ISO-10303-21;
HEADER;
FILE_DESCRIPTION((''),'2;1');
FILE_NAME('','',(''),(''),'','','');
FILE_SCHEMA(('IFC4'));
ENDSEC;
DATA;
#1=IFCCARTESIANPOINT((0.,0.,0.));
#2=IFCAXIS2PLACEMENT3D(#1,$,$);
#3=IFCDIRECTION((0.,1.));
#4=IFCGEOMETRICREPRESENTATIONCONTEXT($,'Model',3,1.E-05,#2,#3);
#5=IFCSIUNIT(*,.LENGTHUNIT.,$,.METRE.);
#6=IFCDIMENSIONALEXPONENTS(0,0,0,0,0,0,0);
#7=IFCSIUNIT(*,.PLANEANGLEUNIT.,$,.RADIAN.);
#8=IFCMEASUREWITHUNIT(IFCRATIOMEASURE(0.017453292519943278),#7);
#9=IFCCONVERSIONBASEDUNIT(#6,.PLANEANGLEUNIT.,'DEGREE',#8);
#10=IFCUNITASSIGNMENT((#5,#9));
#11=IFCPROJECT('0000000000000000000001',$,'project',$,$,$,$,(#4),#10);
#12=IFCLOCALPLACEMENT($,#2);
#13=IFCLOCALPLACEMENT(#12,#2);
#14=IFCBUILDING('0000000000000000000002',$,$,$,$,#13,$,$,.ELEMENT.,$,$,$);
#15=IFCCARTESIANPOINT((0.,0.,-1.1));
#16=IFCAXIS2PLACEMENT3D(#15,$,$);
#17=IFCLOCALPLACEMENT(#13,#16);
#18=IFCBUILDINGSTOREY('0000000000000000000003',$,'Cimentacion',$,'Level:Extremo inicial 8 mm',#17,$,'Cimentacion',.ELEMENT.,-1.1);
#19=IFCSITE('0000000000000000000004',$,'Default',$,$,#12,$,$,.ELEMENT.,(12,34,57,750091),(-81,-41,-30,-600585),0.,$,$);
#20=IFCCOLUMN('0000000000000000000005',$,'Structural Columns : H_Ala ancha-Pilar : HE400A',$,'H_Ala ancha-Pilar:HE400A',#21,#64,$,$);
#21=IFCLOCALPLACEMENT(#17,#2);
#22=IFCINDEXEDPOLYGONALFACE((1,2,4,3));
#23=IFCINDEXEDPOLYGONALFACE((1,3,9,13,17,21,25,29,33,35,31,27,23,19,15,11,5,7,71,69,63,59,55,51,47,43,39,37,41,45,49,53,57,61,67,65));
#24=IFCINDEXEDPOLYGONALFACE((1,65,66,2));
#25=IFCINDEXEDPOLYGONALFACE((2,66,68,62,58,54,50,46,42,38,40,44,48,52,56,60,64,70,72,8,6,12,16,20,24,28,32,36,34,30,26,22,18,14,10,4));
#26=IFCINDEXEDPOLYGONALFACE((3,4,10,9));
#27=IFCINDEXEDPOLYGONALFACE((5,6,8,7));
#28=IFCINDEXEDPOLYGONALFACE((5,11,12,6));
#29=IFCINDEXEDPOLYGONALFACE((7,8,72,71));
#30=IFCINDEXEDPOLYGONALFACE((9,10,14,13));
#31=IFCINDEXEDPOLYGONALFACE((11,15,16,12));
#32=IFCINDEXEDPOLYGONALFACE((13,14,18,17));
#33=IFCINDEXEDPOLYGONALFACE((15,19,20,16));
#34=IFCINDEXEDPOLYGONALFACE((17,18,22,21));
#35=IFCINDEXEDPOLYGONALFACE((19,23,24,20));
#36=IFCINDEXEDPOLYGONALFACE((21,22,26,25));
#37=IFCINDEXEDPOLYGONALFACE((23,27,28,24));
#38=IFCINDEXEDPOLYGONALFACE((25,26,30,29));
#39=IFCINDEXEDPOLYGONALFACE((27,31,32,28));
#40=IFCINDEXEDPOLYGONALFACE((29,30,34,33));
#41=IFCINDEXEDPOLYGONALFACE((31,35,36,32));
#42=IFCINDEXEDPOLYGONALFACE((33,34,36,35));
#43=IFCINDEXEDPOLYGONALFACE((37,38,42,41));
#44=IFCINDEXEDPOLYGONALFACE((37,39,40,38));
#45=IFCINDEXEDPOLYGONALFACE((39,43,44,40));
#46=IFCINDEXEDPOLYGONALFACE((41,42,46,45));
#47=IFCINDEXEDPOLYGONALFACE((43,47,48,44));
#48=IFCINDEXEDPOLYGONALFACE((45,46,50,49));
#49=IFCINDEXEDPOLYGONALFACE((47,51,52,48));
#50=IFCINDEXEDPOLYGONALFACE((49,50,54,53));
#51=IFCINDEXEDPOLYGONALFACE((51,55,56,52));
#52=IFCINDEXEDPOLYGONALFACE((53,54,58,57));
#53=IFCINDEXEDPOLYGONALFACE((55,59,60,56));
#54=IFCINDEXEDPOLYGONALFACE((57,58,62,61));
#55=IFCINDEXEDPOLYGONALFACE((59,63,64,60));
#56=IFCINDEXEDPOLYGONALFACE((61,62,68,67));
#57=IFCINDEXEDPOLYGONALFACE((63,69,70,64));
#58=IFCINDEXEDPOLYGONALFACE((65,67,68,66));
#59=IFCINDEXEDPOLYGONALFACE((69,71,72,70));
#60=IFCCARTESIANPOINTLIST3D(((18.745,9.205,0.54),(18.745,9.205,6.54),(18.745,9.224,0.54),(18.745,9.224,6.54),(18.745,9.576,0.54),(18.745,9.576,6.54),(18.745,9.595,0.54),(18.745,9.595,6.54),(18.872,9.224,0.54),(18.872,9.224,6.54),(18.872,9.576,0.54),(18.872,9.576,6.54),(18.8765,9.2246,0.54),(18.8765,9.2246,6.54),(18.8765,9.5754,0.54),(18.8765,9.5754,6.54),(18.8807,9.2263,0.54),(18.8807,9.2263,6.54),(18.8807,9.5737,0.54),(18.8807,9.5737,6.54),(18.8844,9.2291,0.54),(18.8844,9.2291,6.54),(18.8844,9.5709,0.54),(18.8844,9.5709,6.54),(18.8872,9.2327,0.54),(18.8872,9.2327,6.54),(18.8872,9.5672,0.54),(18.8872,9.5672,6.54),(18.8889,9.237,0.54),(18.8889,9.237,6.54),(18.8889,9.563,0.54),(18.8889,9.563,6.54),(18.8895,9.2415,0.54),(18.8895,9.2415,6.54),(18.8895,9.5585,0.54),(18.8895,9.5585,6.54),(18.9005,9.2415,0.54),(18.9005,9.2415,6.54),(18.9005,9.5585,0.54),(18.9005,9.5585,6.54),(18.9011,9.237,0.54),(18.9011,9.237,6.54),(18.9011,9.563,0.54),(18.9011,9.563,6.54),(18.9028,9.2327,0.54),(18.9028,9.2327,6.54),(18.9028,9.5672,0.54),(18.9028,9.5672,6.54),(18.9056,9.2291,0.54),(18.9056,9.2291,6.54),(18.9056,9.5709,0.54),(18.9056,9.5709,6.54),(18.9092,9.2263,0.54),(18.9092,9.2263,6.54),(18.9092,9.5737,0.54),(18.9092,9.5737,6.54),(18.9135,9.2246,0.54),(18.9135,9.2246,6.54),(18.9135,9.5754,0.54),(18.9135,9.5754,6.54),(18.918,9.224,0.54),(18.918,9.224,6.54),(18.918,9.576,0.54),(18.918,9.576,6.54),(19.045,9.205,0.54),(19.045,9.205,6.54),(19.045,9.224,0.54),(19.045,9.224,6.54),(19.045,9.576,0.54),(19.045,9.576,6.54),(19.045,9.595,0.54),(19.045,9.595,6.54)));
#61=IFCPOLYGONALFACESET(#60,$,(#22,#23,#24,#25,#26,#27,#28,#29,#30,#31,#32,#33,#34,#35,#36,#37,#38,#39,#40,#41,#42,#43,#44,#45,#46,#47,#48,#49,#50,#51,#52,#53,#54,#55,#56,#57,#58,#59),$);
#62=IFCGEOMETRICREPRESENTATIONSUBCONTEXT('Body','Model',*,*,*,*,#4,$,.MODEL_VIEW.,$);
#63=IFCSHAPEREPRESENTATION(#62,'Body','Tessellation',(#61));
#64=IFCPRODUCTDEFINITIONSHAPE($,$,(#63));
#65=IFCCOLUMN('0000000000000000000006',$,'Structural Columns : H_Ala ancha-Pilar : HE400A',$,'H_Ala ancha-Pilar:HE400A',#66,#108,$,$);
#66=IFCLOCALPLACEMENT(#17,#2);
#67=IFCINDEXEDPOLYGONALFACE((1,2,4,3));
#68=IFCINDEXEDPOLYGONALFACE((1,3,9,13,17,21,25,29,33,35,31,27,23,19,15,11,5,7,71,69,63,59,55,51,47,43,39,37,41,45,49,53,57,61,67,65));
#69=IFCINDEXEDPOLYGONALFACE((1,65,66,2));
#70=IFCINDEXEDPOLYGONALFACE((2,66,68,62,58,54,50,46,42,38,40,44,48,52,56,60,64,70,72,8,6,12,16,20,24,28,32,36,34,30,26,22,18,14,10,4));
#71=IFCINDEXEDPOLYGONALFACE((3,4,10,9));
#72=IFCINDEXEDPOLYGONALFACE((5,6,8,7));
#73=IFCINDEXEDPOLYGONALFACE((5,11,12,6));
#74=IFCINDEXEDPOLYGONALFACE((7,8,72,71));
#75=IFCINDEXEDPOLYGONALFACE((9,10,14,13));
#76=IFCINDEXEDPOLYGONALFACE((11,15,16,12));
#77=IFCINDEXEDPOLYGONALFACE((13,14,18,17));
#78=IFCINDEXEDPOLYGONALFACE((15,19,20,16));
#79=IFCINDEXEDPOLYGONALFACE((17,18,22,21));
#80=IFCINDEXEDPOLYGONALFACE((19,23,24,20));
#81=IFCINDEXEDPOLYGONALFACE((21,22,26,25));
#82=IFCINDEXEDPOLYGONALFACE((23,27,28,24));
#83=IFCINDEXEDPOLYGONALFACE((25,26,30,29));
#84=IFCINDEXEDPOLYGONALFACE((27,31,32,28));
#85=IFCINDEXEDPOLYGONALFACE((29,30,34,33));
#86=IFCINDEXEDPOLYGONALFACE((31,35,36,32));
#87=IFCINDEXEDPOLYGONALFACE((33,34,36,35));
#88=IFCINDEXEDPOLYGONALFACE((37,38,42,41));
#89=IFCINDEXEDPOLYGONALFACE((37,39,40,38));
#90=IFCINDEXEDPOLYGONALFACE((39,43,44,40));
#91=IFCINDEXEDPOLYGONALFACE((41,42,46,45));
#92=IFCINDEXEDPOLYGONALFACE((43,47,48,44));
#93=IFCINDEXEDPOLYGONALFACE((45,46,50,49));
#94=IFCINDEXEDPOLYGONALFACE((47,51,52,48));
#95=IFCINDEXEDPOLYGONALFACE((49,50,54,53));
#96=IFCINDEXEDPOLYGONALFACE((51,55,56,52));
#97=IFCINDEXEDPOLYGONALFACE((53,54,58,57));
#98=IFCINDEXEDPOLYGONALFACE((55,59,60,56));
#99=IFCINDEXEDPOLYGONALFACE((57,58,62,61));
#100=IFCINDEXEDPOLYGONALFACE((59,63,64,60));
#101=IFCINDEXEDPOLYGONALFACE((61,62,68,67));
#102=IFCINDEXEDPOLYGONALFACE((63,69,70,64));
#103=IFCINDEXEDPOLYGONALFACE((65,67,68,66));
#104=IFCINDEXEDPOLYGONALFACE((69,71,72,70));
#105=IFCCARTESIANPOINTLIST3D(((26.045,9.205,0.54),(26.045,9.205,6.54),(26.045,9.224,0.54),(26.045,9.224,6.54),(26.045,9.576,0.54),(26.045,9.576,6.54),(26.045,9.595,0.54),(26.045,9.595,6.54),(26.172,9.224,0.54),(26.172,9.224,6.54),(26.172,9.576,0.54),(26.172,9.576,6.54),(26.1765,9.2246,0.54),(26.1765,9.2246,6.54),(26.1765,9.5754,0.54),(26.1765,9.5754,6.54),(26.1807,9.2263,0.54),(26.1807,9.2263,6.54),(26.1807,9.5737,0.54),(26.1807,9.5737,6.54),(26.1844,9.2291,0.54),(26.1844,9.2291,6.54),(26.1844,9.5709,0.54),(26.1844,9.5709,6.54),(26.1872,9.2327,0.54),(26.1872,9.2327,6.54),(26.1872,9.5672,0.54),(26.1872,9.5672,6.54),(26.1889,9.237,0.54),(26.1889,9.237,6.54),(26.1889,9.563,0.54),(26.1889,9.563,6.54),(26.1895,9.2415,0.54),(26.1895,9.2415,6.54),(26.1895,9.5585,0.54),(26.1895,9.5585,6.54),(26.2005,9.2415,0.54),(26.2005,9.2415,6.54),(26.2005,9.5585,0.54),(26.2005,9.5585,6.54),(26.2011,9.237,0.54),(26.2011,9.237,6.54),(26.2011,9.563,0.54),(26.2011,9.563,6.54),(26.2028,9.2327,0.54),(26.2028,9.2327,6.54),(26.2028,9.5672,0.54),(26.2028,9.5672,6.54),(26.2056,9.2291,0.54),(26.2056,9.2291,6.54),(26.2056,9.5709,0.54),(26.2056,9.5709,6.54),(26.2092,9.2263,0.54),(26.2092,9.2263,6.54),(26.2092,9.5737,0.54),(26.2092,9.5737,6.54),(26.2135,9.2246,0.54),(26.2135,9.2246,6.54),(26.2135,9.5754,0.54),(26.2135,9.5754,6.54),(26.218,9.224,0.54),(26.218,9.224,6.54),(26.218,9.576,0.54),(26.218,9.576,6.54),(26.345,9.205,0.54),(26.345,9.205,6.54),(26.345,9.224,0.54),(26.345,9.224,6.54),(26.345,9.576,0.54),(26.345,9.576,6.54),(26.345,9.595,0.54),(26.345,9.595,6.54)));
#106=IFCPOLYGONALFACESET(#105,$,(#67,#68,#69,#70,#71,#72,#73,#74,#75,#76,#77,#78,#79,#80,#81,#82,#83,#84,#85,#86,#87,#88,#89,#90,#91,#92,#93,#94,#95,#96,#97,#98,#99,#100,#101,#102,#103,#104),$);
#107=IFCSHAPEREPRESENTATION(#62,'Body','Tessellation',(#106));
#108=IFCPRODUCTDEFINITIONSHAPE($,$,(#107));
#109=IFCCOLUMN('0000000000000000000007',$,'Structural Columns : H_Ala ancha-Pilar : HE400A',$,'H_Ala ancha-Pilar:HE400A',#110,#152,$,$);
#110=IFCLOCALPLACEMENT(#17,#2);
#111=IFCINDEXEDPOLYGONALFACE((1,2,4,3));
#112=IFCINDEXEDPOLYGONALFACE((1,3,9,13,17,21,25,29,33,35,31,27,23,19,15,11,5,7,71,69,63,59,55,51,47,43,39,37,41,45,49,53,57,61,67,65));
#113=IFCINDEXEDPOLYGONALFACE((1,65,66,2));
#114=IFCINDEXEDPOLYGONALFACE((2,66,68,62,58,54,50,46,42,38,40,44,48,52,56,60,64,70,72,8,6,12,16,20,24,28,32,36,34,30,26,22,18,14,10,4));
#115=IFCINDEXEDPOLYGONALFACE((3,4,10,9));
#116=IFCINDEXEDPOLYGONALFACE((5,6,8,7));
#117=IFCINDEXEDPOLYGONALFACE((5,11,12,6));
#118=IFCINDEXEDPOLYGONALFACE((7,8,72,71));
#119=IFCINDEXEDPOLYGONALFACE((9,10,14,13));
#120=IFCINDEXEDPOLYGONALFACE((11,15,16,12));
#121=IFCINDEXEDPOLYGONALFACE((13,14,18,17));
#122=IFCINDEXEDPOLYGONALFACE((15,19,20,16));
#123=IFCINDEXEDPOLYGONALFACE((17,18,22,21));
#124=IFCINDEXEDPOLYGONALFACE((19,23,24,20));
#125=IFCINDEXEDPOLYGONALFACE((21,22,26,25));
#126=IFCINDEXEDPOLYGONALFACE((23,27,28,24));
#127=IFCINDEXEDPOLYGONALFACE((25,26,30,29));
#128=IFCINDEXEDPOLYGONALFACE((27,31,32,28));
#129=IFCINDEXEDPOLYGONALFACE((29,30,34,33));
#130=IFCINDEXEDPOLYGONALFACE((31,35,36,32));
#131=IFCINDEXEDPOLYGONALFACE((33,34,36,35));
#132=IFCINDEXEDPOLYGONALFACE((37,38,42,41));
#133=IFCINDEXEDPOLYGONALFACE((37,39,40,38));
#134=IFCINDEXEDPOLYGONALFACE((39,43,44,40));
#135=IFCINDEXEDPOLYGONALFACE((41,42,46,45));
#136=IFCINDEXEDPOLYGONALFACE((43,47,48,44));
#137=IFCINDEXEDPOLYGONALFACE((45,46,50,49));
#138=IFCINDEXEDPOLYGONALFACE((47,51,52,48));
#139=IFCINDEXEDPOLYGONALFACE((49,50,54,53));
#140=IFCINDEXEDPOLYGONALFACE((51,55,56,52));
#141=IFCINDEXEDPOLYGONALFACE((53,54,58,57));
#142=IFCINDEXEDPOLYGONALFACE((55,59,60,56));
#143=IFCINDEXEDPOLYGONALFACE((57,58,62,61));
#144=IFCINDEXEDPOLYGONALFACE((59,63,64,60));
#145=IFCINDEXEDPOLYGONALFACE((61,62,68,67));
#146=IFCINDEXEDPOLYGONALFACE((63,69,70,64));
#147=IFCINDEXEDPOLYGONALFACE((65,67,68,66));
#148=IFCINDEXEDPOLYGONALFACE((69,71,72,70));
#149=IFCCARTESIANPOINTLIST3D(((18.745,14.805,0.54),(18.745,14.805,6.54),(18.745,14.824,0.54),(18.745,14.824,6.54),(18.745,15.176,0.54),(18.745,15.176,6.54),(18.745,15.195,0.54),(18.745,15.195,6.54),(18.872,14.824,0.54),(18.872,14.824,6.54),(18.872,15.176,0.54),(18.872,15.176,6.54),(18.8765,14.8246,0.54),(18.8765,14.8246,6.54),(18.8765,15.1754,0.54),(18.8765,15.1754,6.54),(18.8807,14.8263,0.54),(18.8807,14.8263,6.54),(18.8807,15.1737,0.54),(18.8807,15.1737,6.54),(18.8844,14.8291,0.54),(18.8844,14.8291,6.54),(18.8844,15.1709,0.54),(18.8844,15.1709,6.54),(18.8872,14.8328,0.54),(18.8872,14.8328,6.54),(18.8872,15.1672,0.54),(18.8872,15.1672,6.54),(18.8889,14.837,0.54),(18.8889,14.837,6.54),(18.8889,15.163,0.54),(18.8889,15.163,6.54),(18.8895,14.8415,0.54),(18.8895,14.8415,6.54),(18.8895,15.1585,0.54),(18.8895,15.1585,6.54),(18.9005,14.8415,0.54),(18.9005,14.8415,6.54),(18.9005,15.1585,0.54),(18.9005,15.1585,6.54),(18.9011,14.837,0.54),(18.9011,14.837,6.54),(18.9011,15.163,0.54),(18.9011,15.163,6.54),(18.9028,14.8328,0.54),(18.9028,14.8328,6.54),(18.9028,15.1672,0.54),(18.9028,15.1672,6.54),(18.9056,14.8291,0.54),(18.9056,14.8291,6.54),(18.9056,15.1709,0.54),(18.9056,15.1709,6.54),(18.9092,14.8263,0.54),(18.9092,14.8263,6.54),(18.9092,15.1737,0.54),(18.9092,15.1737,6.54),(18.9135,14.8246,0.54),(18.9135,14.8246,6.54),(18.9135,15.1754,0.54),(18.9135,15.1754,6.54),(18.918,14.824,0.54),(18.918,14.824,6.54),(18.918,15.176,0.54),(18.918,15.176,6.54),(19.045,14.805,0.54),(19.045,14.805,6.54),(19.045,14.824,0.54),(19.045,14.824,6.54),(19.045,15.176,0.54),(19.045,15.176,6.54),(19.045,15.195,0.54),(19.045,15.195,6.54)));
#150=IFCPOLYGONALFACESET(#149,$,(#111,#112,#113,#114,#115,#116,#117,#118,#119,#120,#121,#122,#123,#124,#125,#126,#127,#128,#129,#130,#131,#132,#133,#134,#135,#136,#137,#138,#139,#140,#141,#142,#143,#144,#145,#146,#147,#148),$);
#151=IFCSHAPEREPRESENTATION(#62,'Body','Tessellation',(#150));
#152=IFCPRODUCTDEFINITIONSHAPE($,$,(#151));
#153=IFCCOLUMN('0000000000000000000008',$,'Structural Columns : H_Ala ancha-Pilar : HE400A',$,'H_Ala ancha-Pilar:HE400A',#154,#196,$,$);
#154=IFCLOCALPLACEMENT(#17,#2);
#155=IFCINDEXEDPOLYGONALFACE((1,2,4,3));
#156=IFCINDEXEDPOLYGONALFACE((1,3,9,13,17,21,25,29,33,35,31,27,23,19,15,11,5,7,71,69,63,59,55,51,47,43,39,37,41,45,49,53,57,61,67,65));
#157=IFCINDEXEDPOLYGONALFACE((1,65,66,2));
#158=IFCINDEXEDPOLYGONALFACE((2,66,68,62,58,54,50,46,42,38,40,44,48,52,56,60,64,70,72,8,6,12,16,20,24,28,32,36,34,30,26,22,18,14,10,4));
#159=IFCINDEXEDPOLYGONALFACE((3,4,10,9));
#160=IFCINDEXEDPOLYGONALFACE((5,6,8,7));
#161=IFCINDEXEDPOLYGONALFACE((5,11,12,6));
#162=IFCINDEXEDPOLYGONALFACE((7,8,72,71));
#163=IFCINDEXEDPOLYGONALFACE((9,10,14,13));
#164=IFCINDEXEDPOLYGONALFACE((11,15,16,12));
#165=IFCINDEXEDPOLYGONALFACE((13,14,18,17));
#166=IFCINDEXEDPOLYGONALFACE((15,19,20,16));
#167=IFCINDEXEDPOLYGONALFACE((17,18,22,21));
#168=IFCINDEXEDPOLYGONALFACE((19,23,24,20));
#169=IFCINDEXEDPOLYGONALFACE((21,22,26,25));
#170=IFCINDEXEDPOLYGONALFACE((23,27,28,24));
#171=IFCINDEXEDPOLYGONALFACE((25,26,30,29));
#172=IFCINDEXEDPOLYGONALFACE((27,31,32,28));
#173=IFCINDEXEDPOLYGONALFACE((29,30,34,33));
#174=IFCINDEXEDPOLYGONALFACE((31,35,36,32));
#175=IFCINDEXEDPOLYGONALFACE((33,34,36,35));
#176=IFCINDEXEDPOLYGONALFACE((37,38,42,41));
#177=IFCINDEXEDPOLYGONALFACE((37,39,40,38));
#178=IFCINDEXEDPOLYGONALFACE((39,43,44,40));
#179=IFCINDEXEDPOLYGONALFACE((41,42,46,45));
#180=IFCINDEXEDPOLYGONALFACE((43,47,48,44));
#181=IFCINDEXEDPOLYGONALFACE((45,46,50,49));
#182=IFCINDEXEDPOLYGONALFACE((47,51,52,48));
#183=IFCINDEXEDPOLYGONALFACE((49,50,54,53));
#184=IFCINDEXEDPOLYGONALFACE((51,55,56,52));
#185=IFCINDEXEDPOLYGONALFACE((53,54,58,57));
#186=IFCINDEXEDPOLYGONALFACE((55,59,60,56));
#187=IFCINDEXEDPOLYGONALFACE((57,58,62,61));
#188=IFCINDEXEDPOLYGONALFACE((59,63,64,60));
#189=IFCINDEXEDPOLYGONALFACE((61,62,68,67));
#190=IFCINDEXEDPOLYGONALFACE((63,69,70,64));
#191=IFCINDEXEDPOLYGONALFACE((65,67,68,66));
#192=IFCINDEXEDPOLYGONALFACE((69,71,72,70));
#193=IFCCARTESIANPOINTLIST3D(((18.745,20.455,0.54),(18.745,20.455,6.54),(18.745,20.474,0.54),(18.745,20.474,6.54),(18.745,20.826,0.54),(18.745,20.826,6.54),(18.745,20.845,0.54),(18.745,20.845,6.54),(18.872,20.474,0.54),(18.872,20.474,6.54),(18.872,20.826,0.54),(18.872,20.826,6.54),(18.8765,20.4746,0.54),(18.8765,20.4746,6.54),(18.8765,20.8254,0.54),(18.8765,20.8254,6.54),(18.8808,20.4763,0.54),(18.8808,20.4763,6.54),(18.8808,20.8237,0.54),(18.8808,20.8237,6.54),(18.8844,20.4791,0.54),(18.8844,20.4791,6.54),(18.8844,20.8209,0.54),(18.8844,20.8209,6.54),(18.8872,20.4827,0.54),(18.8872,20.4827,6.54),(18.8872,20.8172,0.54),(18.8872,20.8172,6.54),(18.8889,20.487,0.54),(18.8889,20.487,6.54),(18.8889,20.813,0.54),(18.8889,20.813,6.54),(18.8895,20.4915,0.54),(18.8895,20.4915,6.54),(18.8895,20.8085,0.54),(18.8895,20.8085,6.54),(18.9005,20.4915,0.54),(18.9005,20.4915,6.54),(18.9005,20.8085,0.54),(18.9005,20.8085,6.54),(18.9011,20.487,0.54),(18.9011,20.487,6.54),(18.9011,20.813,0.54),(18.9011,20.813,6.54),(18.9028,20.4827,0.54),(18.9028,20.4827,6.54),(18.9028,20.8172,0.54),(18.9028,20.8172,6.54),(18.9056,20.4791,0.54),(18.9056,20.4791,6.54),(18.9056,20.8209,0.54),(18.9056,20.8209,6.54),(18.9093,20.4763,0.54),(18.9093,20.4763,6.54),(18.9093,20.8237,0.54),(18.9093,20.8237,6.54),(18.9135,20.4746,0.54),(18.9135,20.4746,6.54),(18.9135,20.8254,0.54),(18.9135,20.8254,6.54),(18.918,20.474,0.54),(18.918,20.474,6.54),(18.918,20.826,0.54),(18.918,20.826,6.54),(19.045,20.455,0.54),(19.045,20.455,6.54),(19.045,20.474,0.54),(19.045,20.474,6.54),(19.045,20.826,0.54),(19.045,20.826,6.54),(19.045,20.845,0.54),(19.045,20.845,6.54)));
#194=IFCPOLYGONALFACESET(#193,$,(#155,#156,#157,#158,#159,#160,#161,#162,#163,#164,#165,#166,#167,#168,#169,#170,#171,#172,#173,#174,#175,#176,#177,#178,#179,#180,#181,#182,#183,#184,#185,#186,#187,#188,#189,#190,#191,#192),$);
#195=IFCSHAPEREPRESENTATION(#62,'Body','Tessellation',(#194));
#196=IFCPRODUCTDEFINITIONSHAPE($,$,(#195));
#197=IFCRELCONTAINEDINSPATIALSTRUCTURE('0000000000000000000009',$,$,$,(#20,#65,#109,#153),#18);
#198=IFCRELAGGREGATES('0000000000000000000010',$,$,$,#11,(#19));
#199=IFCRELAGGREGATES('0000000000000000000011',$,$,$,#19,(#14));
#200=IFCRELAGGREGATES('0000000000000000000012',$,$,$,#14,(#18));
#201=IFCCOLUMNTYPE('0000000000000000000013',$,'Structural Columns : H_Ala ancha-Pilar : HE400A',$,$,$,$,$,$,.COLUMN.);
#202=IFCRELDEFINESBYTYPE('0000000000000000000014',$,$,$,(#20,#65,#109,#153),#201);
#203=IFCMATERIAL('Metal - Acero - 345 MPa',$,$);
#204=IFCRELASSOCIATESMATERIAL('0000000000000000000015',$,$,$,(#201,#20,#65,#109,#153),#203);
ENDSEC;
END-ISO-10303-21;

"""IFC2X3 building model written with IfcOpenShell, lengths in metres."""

from ifc_helpers import new_model, entity, si_unit, converted_unit, direction, frame, frame_2d, origin, place, context, subcontext, project, spatial, polyline, circle_curve, parameter, trimmed, segment, composite_curve, outline, extrude, source, transform, mapped, material, type_object, type_shapes, element, save


model = new_model("IFC2X3")

# Units and contexts
model_context = context("Model", 3, precision=1e-05, world=origin(), true_north=direction((0.0, 1.0)))
body_context = subcontext(model_context, "Body", "Model", "MODEL_VIEW")
ifc_project = project(units=[si_unit("LENGTHUNIT", "METRE"), converted_unit("PLANEANGLEUNIT", "DEGREE", entity("IfcRatioMeasure", 0.017453292519943278), si_unit("PLANEANGLEUNIT", "RADIAN"), dimensions=[0, 0, 0, 0, 0, 0, 0])], contexts=[model_context])

# Site, building, storey
site_placement = place(None, origin())
site = spatial("IfcSite", under=ifc_project, at=site_placement, Name="Default", CompositionType="ELEMENT", RefLatitude=(12, 34, 57, 750091), RefLongitude=(-81, -41, -30, -600585), RefElevation=0.0)
building_placement = place(site_placement, origin())
building = spatial("IfcBuilding", under=site, at=building_placement, CompositionType="ELEMENT")
storey_placement = place(building_placement, frame((0.0, 0.0, -1.1)))
storey = spatial("IfcBuildingStorey", under=building, at=storey_placement, Name="Cimentacion", ObjectType="Level:Extremo inicial 8 mm", LongName="Cimentacion", CompositionType="ELEMENT", Elevation=-1.1)

# Columns
ifc_material = material(Name="Metal - Acero - 345 MPa")
column_type_1 = type_object("IfcColumnType", Name="Structural Columns : H_Ala ancha-Pilar : HE400A", PredefinedType="COLUMN", material=ifc_material)
shared_shape_1 = source(origin(), body_context, "Body", "SweptSolid", [
    extrude(outline(composite_curve([segment(polyline([(0.176, -0.15), (0.195, -0.15)]), True, "CONTINUOUS"), segment(polyline([(0.195, -0.15), (0.195, 0.15)]), True, "CONTINUOUS"), segment(polyline([(0.195, 0.15), (0.176, 0.15)]), True, "CONTINUOUS"), segment(polyline([(0.176, 0.15), (0.176, 0.023)]), True, "CONTINUOUS"), segment(trimmed(circle_curve(frame_2d((0.1585, 0.023), x_axis=(1.0, 0.0)), 0.0175), [parameter(270.0)], [parameter(0.0)], True, "PARAMETER"), False, "CONTINUOUS"), segment(polyline([(0.1585, 0.0055), (-0.1585, 0.0055)]), True, "CONTINUOUS"), segment(trimmed(circle_curve(frame_2d((-0.1585, 0.023), x_axis=(0.0, -1.0)), 0.0175), [parameter(270.0)], [parameter(0.0)], True, "PARAMETER"), False, "CONTINUOUS"), segment(polyline([(-0.176, 0.023), (-0.176, 0.15)]), True, "CONTINUOUS"), segment(polyline([(-0.176, 0.15), (-0.195, 0.15)]), True, "CONTINUOUS"), segment(polyline([(-0.195, 0.15), (-0.195, -0.15)]), True, "CONTINUOUS"), segment(polyline([(-0.195, -0.15), (-0.176, -0.15)]), True, "CONTINUOUS"), segment(polyline([(-0.176, -0.15), (-0.176, -0.023)]), True, "CONTINUOUS"), segment(trimmed(circle_curve(frame_2d((-0.1585, -0.023), x_axis=(-1.0, 0.0)), 0.0175), [parameter(270.0)], [parameter(0.0)], True, "PARAMETER"), False, "CONTINUOUS"), segment(polyline([(-0.1585, -0.0055), (0.1585, -0.0055)]), True, "CONTINUOUS"), segment(trimmed(circle_curve(frame_2d((0.1585, -0.023), x_axis=(0.0, 1.0)), 0.0175), [parameter(270.0)], [parameter(0.0)], True, "PARAMETER"), False, "CONTINUOUS"), segment(polyline([(0.176, -0.023), (0.176, -0.15)]), True, "CONTINUOUS")], self_intersect=False)), frame((0.0, 0.0, -0.56), z_axis=(0.0, 0.0, 1.0), x_axis=(0.0, -1.0, 0.0)), (0.0, 0.0, 1.0), 6.0),
])
type_shapes(column_type_1, [shared_shape_1])
for number, where, z_axis, x_axis, name in (
    (1, (18.895, 9.4, 1.1), (0.0, 0.0, 1.0), (-1.0, 0.0, 0.0), "Structural Columns : H_Ala ancha-Pilar : HE400A"),
    (2, (26.195, 9.4, 1.1), (0.0, 0.0, 1.0), (-1.0, 0.0, 0.0), "Structural Columns : H_Ala ancha-Pilar : HE400A"),
    (3, (18.895, 15.0, 1.1), (0.0, 0.0, 1.0), (-1.0, 0.0, 0.0), "Structural Columns : H_Ala ancha-Pilar : HE400A"),
    (4, (18.895, 20.65, 1.1), (0.0, 0.0, 1.0), (-1.0, 0.0, 0.0), "Structural Columns : H_Ala ancha-Pilar : HE400A"),
):
    element("IfcColumn", number, at=place(storey_placement, frame(where, z_axis=z_axis, x_axis=x_axis)), inside=storey, type_object=column_type_1, material=ifc_material, Name=name, ObjectType="H_Ala ancha-Pilar:HE400A", context=body_context, shape_type="MappedRepresentation", body=[
        mapped(shared_shape_1, transform((0.0, 0.0, 0.0), scale=1.0)),
    ])

save(model, "model.ifc")
